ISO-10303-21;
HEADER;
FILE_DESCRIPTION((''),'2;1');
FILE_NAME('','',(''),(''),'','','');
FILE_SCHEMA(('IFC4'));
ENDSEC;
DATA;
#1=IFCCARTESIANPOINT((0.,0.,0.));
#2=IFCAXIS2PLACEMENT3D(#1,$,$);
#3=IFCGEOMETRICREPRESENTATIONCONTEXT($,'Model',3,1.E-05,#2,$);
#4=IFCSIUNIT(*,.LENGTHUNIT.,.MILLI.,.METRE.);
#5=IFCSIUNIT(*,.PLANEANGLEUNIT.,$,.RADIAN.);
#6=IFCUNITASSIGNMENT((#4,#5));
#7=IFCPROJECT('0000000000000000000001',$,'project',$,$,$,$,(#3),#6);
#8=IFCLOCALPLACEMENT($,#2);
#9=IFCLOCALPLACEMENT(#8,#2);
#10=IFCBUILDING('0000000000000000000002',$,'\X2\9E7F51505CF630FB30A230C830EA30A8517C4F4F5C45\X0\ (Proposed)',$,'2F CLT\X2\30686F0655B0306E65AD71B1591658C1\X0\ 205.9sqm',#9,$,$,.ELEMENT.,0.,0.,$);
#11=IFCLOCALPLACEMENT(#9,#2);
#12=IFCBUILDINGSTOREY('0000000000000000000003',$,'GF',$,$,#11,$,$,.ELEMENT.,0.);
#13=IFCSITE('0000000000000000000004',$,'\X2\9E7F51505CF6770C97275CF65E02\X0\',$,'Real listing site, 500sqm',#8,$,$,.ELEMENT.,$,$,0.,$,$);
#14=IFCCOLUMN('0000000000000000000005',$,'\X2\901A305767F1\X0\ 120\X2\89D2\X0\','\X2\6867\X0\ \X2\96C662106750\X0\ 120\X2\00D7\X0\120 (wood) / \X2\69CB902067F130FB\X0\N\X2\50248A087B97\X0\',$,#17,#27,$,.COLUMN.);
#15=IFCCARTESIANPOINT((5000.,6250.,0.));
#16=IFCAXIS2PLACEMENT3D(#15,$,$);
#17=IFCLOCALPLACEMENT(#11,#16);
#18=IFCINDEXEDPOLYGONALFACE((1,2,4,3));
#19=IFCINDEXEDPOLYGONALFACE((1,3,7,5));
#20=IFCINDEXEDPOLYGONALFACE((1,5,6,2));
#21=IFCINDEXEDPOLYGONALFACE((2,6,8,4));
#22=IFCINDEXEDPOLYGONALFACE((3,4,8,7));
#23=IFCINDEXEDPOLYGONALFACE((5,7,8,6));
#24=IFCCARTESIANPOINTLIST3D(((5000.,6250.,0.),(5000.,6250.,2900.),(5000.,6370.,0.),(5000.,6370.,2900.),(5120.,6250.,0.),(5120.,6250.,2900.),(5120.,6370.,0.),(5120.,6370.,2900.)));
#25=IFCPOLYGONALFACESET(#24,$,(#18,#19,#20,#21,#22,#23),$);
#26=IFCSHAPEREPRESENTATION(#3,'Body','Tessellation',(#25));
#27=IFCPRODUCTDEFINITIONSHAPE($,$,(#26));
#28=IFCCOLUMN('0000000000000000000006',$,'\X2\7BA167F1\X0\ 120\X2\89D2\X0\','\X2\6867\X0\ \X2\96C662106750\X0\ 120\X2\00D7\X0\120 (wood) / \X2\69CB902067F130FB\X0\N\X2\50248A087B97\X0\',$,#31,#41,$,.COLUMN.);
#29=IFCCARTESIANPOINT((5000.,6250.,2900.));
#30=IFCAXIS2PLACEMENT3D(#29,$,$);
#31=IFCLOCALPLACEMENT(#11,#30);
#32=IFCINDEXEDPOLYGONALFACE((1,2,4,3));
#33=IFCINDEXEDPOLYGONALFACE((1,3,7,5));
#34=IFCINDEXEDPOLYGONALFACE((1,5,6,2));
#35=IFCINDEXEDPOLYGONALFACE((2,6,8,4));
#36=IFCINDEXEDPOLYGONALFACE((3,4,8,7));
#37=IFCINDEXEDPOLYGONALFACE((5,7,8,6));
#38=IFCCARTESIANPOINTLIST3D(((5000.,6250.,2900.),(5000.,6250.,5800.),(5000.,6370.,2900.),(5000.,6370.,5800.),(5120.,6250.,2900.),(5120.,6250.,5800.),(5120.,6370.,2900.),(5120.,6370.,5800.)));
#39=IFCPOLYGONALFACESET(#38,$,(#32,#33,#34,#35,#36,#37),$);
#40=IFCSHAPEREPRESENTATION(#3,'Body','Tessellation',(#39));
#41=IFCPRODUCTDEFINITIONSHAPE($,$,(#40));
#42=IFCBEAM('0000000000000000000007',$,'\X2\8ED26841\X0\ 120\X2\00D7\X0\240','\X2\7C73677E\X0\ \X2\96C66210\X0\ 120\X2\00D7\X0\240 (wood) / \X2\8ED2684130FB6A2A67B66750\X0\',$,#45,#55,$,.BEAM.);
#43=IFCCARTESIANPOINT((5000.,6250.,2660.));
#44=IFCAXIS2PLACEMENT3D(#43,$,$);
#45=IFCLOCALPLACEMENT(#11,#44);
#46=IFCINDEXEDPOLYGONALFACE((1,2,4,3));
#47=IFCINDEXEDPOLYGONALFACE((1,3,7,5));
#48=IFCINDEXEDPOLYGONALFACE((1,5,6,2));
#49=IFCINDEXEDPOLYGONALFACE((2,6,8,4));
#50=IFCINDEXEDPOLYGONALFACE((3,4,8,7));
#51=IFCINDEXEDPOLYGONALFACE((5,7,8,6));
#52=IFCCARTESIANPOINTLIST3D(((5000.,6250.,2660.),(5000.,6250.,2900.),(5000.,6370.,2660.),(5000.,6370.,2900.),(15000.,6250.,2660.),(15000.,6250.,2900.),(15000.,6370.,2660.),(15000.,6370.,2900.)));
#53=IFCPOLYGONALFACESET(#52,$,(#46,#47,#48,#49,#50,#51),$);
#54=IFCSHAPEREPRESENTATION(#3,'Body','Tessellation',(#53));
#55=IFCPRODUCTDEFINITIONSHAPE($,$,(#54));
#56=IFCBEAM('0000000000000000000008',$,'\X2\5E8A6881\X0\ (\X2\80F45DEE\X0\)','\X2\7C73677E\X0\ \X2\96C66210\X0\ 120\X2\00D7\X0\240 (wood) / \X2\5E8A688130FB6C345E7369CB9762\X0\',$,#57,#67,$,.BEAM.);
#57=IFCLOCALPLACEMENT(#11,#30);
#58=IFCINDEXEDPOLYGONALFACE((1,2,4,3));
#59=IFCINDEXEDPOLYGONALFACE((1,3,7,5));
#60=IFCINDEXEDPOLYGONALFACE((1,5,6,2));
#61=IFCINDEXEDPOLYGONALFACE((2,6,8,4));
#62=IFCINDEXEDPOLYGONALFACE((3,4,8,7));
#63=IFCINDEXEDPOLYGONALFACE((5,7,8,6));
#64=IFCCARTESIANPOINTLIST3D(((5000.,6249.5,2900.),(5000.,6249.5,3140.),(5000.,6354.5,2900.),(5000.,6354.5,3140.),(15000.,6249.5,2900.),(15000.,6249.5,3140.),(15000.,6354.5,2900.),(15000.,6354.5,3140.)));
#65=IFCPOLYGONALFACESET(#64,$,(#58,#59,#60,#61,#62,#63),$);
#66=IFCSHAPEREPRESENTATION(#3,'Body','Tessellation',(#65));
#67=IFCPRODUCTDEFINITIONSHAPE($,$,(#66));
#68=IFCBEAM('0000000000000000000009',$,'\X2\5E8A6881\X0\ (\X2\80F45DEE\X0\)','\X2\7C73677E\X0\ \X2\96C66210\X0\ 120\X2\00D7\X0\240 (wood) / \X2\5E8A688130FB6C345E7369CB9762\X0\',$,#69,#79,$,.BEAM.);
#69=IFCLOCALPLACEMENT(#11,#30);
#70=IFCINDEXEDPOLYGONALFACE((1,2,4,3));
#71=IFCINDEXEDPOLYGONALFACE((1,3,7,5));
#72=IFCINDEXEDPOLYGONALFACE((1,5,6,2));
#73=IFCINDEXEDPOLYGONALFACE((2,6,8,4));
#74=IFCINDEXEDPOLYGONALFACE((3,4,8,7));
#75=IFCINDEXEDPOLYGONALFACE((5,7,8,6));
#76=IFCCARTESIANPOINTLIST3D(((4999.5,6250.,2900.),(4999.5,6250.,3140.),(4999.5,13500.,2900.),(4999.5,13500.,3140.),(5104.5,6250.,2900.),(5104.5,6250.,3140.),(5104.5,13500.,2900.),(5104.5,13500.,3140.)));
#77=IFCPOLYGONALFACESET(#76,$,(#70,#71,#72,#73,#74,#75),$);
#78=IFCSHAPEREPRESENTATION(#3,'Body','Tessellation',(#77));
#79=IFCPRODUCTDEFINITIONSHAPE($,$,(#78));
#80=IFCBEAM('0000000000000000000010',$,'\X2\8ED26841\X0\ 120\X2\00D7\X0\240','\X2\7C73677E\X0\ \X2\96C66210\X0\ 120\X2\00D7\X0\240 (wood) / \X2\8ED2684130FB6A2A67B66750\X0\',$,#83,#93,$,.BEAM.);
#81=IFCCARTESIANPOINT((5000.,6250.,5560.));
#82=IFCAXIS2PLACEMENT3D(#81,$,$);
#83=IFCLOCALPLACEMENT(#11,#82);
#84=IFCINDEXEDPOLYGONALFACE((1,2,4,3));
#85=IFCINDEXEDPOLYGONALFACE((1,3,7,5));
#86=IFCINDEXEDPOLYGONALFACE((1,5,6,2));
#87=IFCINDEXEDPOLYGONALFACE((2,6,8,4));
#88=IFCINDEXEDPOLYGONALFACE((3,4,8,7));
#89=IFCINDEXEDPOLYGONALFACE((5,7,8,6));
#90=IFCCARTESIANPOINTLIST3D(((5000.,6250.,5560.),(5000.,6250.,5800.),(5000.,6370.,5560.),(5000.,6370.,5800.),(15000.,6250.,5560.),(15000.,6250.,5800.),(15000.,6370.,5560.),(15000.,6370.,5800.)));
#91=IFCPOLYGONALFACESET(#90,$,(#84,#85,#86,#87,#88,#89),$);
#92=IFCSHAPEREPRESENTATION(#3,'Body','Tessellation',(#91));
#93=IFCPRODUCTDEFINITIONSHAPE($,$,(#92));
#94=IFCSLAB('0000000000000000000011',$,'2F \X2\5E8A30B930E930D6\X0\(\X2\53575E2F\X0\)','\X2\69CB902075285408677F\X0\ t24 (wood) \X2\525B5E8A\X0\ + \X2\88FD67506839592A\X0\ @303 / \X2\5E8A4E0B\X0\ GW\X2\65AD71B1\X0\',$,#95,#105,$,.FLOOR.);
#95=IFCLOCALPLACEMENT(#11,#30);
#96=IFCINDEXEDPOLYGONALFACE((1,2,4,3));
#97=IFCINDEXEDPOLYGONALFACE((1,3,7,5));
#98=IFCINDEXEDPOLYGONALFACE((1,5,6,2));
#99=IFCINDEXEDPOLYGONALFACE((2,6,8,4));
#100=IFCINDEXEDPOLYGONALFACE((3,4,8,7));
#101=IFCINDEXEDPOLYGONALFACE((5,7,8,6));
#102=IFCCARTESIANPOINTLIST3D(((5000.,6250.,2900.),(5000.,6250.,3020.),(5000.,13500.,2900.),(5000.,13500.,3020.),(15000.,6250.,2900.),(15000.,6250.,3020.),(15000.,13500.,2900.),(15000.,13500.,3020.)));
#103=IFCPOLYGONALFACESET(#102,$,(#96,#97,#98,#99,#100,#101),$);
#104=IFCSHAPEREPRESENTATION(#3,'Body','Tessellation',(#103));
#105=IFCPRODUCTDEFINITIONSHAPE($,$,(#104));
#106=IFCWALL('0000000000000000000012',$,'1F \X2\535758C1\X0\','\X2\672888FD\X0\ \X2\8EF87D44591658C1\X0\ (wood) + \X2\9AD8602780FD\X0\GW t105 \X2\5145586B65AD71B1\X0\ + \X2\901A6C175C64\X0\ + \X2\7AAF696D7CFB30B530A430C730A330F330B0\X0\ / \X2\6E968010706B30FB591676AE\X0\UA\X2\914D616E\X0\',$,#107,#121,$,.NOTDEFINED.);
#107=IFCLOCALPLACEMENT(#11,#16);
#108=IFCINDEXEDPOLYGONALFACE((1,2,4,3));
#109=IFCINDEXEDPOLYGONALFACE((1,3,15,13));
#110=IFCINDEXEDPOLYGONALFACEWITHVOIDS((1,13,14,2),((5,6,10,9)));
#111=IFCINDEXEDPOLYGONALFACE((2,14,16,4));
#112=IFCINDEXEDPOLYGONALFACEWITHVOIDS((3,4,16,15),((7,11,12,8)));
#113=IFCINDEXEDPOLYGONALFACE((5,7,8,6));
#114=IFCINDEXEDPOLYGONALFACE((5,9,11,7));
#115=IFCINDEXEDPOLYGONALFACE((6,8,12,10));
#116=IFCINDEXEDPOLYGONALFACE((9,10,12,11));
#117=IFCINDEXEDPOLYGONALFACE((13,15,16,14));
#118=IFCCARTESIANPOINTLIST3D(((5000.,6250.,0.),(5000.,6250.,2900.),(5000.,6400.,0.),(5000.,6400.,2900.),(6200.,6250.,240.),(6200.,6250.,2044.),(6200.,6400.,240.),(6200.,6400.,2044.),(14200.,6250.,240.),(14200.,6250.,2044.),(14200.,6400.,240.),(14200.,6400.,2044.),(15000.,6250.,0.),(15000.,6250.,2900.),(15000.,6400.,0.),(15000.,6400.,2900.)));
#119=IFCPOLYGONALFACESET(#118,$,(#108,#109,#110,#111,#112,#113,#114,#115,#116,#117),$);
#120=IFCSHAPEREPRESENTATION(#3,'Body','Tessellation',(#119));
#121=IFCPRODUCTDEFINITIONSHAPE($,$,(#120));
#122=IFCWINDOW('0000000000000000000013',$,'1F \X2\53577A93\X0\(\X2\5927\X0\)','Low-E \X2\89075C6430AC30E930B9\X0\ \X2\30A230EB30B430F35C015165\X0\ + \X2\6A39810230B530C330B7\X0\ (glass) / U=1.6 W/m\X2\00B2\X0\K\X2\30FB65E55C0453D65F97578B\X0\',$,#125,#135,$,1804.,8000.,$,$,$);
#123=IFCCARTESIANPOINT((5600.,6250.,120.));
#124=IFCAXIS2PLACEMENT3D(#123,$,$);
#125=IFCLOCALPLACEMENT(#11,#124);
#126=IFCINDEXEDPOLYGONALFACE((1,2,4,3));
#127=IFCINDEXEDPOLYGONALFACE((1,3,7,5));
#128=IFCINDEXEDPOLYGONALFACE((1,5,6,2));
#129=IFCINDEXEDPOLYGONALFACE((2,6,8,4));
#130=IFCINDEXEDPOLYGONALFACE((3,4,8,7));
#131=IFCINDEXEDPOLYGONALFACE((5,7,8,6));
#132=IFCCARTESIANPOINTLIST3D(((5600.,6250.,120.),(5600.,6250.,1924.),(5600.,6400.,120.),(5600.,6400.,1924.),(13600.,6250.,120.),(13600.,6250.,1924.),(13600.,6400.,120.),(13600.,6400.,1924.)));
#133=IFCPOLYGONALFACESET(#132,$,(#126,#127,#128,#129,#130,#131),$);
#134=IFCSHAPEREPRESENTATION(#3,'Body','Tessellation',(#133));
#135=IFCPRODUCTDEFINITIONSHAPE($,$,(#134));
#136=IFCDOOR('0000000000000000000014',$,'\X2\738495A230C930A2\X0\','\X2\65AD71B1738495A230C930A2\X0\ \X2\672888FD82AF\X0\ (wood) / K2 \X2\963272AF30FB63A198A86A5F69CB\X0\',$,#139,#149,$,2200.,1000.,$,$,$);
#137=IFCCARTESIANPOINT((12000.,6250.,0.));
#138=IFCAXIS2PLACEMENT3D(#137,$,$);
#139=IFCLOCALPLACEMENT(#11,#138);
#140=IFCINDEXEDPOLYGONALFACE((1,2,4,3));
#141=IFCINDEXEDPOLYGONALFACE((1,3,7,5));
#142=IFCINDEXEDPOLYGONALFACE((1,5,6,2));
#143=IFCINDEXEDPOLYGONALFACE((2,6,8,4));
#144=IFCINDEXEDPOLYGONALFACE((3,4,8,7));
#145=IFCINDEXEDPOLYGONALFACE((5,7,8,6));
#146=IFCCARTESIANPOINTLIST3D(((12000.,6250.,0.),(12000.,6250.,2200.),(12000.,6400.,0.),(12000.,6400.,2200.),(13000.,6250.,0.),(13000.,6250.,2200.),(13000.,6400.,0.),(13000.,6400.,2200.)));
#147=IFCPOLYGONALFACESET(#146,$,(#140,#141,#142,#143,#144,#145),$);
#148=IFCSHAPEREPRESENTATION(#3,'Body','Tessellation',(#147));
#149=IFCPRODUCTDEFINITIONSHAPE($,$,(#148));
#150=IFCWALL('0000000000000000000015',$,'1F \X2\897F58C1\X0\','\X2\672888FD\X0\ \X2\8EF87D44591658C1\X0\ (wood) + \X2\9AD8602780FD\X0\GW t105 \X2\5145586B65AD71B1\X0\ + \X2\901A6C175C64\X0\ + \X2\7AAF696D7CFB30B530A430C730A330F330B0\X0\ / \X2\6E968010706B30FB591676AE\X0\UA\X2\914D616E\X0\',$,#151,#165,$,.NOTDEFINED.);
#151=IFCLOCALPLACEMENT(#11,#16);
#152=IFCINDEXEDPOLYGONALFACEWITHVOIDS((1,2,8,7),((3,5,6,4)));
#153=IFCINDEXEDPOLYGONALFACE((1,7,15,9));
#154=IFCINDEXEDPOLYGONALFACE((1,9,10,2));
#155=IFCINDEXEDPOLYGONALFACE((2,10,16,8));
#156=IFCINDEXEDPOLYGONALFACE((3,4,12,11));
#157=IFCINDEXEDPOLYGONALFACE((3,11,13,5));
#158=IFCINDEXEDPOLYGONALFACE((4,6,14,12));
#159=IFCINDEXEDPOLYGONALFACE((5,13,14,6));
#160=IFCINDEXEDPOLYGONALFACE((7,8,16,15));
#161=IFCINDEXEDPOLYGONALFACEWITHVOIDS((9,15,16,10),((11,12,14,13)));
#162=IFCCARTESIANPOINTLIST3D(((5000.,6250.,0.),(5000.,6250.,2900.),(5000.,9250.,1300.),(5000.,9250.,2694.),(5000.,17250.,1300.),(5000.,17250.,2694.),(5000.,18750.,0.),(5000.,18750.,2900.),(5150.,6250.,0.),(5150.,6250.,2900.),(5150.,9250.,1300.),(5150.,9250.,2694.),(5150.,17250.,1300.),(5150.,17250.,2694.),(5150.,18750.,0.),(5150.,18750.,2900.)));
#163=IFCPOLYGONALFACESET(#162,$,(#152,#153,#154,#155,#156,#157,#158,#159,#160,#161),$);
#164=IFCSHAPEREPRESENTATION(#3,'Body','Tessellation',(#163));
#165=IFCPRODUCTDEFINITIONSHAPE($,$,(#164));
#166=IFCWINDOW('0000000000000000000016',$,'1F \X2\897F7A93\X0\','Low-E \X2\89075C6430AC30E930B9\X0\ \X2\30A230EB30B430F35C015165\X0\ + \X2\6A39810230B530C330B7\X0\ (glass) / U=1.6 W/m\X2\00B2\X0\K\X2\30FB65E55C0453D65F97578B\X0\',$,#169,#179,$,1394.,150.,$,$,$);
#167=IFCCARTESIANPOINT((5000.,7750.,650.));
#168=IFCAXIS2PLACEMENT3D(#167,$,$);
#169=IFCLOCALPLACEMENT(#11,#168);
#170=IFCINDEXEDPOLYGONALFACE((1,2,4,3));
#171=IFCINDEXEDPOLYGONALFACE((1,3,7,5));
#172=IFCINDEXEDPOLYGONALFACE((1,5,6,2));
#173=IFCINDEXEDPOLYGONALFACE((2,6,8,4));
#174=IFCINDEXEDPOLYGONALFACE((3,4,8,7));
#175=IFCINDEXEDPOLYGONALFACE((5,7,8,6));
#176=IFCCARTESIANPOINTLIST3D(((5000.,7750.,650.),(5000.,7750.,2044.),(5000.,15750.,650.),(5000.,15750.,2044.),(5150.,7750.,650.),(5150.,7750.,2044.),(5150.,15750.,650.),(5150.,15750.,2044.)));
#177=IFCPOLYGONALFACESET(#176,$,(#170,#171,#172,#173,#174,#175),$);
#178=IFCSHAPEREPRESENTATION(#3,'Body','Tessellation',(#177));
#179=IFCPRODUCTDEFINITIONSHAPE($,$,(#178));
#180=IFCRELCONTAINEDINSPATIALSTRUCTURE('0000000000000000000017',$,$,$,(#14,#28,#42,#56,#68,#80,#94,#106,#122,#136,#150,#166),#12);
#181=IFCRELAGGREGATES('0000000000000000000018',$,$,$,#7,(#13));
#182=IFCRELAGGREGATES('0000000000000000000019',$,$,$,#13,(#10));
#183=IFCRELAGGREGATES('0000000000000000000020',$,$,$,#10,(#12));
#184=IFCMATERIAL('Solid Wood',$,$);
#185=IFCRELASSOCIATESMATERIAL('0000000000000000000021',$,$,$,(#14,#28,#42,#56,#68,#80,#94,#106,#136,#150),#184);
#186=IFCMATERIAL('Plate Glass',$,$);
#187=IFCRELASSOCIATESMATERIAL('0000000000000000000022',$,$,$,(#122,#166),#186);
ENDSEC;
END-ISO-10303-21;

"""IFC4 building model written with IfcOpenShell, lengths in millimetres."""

from ifc_helpers import new_model, si_unit, frame, frame_2d, origin, place, context, project, spatial, rectangle, extrude, material, element, fill, save


model = new_model("IFC4")

# Units and contexts
model_context = context("Model", 3, precision=1e-05, world=origin())
ifc_project = project(units=[si_unit("LENGTHUNIT", "METRE", prefix="MILLI"), si_unit("PLANEANGLEUNIT", "RADIAN")], contexts=[model_context])

# Site, building, storey
site_placement = place(None, origin())
site = spatial("IfcSite", under=ifc_project, at=site_placement, Name="鹿児島県霧島市", ObjectType="Real listing site, 500sqm", CompositionType="ELEMENT", RefElevation=0.0)
building_placement = place(site_placement, origin())
building = spatial("IfcBuilding", under=site, at=building_placement, Name="鹿児島・アトリエ兼住居 (Proposed)", ObjectType="2F CLTと漆喰の断熱外壁 205.9sqm", CompositionType="ELEMENT", ElevationOfRefHeight=0.0, ElevationOfTerrain=0.0)
storey_placement = place(building_placement, origin())
storey = spatial("IfcBuildingStorey", under=building, at=storey_placement, Name="GF", CompositionType="ELEMENT", Elevation=0.0)

# Columns
ifc_material_1 = material(Name="Solid Wood")
column_1_placement = place(storey_placement, frame((5000.0, 6250.0, 0.0)))
element("IfcColumn", 1, at=column_1_placement, inside=storey, material=ifc_material_1, Name="通し柱 120角", Description="桧 集成材 120×120 (wood) / 構造柱・N値計算", PredefinedType="COLUMN", context=model_context, shape_type="SweptSolid", body=[
    extrude(rectangle(XDim=120.0, YDim=120.0, at=frame_2d((60.0, 60.0))), frame((5000.0, 6250.0, 0.0)), (0.0, 0.0, 1.0), 2900.0),
])
column_2_placement = place(storey_placement, frame((5000.0, 6250.0, 2900.0)))
element("IfcColumn", 2, at=column_2_placement, inside=storey, material=ifc_material_1, Name="管柱 120角", Description="桧 集成材 120×120 (wood) / 構造柱・N値計算", PredefinedType="COLUMN", context=model_context, shape_type="SweptSolid", body=[
    extrude(rectangle(XDim=120.0, YDim=120.0, at=frame_2d((60.0, 60.0))), frame((5000.0, 6250.0, 2900.0)), (0.0, 0.0, 1.0), 2900.0),
])

# Beams
beam_1_placement = place(storey_placement, frame((5000.0, 6250.0, 2660.0)))
element("IfcBeam", 3, at=beam_1_placement, inside=storey, material=ifc_material_1, Name="軒桁 120×240", Description="米松 集成 120×240 (wood) / 軒桁・横架材", PredefinedType="BEAM", context=model_context, shape_type="SweptSolid", body=[
    extrude(rectangle(XDim=10000.0, YDim=120.0, at=frame_2d((5000.0, 60.0))), frame((5000.0, 6250.0, 2660.0)), (0.0, 0.0, 1.0), 240.0),
])
beam_2_placement = place(storey_placement, frame((5000.0, 6250.0, 2900.0)))
element("IfcBeam", 4, at=beam_2_placement, inside=storey, material=ifc_material_1, Name="床梁 (胴差)", Description="米松 集成 120×240 (wood) / 床梁・水平構面", PredefinedType="BEAM", context=model_context, shape_type="SweptSolid", body=[
    extrude(rectangle(XDim=10000.0, YDim=105.0, at=frame_2d((5000.0, 52.0))), frame((5000.0, 6250.0, 2900.0)), (0.0, 0.0, 1.0), 240.0),
])
beam_3_placement = place(storey_placement, frame((5000.0, 6250.0, 2900.0)))
element("IfcBeam", 5, at=beam_3_placement, inside=storey, material=ifc_material_1, Name="床梁 (胴差)", Description="米松 集成 120×240 (wood) / 床梁・水平構面", PredefinedType="BEAM", context=model_context, shape_type="SweptSolid", body=[
    extrude(rectangle(XDim=105.0, YDim=7250.0, at=frame_2d((52.0, 3625.0))), frame((5000.0, 6250.0, 2900.0)), (0.0, 0.0, 1.0), 240.0),
])
beam_4_placement = place(storey_placement, frame((5000.0, 6250.0, 5560.0)))
element("IfcBeam", 6, at=beam_4_placement, inside=storey, material=ifc_material_1, Name="軒桁 120×240", Description="米松 集成 120×240 (wood) / 軒桁・横架材", PredefinedType="BEAM", context=model_context, shape_type="SweptSolid", body=[
    extrude(rectangle(XDim=10000.0, YDim=120.0, at=frame_2d((5000.0, 60.0))), frame((5000.0, 6250.0, 5560.0)), (0.0, 0.0, 1.0), 240.0),
])

# Slab
slab_1_placement = place(storey_placement, frame((5000.0, 6250.0, 2900.0)))
element("IfcSlab", 7, at=slab_1_placement, inside=storey, material=ifc_material_1, Name="2F 床スラブ(南帯)", Description="構造用合板 t24 (wood) 剛床 + 製材根太 @303 / 床下 GW断熱", PredefinedType="FLOOR", context=model_context, shape_type="SweptSolid", body=[
    extrude(rectangle(XDim=10000.0, YDim=7250.0, at=frame_2d((5000.0, 3625.0))), frame((5000.0, 6250.0, 2900.0)), (0.0, 0.0, 1.0), 120.0),
])

# Wall, openings, window, door
wall_1_placement = place(storey_placement, frame((5000.0, 6250.0, 0.0)))
wall_1 = element("IfcWall", 8, at=wall_1_placement, inside=storey, material=ifc_material_1, Name="1F 南壁", Description="木製 軸組外壁 (wood) + 高性能GW t105 充填断熱 + 通気層 + 窯業系サイディング / 準耐火・外皮UA配慮", PredefinedType="NOTDEFINED", context=model_context, shape_type="SweptSolid", body=[
    extrude(rectangle(XDim=10000.0, YDim=150.0, at=frame_2d((5000.0, 75.0))), frame((5000.0, 6250.0, 0.0)), (0.0, 0.0, 1.0), 2900.0),
])
opening_1_placement = place(storey_placement, frame((5600.0, 6250.0, 120.0)))
opening_1 = element("IfcOpeningElement", 9, at=opening_1_placement, cuts=wall_1, PredefinedType="NOTDEFINED", context=model_context, shape_type="SweptSolid", body=[
    extrude(rectangle(XDim=8000.0, YDim=150.0, at=frame_2d((4000.0, 75.0))), frame((5600.0, 6250.0, 120.0)), (0.0, 0.0, 1.0), 1804.0),
])
opening_2_placement = place(storey_placement, frame((12000.0, 6250.0, 0.0)))
opening_2 = element("IfcOpeningElement", 10, at=opening_2_placement, cuts=wall_1, PredefinedType="NOTDEFINED", context=model_context, shape_type="SweptSolid", body=[
    extrude(rectangle(XDim=1000.0, YDim=150.0, at=frame_2d((500.0, 75.0))), frame((12000.0, 6250.0, 0.0)), (0.0, 0.0, 1.0), 2200.0),
])
ifc_material_2 = material(Name="Plate Glass")
window_1_placement = place(storey_placement, frame((5600.0, 6250.0, 120.0)))
window_1 = element("IfcWindow", 11, at=window_1_placement, inside=storey, material=ifc_material_2, Name="1F 南窓(大)", Description="Low-E 複層ガラス アルゴン封入 + 樹脂サッシ (glass) / U=1.6 W/m²K・日射取得型", OverallHeight=1804.0, OverallWidth=8000.0, context=model_context, shape_type="SweptSolid", body=[
    extrude(rectangle(XDim=8000.0, YDim=150.0, at=frame_2d((4000.0, 75.0))), frame((5600.0, 6250.0, 120.0)), (0.0, 0.0, 1.0), 1804.0),
])
fill(opening_1, window_1)
door_placement = place(storey_placement, frame((12000.0, 6250.0, 0.0)))
door = element("IfcDoor", 12, at=door_placement, inside=storey, material=ifc_material_1, Name="玄関ドア", Description="断熱玄関ドア 木製芯 (wood) / K2 防犯・採風機構", OverallHeight=2200.0, OverallWidth=1000.0, context=model_context, shape_type="SweptSolid", body=[
    extrude(rectangle(XDim=1000.0, YDim=150.0, at=frame_2d((500.0, 75.0))), frame((12000.0, 6250.0, 0.0)), (0.0, 0.0, 1.0), 2200.0),
])
fill(opening_2, door)

# Wall, opening, window
wall_2_placement = place(storey_placement, frame((5000.0, 6250.0, 0.0)))
wall_2 = element("IfcWall", 13, at=wall_2_placement, inside=storey, material=ifc_material_1, Name="1F 西壁", Description="木製 軸組外壁 (wood) + 高性能GW t105 充填断熱 + 通気層 + 窯業系サイディング / 準耐火・外皮UA配慮", PredefinedType="NOTDEFINED", context=model_context, shape_type="SweptSolid", body=[
    extrude(rectangle(XDim=150.0, YDim=12500.0, at=frame_2d((75.0, 6250.0))), frame((5000.0, 6250.0, 0.0)), (0.0, 0.0, 1.0), 2900.0),
])
opening_3_placement = place(storey_placement, frame((5000.0, 7750.0, 650.0)))
opening_3 = element("IfcOpeningElement", 14, at=opening_3_placement, cuts=wall_2, PredefinedType="NOTDEFINED", context=model_context, shape_type="SweptSolid", body=[
    extrude(rectangle(XDim=150.0, YDim=8000.0, at=frame_2d((75.0, 4000.0))), frame((5000.0, 7750.0, 650.0)), (0.0, 0.0, 1.0), 1394.0),
])
window_2_placement = place(storey_placement, frame((5000.0, 7750.0, 650.0)))
window_2 = element("IfcWindow", 15, at=window_2_placement, inside=storey, material=ifc_material_2, Name="1F 西窓", Description="Low-E 複層ガラス アルゴン封入 + 樹脂サッシ (glass) / U=1.6 W/m²K・日射取得型", OverallHeight=1394.0, OverallWidth=150.0, context=model_context, shape_type="SweptSolid", body=[
    extrude(rectangle(XDim=150.0, YDim=8000.0, at=frame_2d((75.0, 4000.0))), frame((5000.0, 7750.0, 650.0)), (0.0, 0.0, 1.0), 1394.0),
])
fill(opening_3, window_2)

save(model, "model.ifc")
